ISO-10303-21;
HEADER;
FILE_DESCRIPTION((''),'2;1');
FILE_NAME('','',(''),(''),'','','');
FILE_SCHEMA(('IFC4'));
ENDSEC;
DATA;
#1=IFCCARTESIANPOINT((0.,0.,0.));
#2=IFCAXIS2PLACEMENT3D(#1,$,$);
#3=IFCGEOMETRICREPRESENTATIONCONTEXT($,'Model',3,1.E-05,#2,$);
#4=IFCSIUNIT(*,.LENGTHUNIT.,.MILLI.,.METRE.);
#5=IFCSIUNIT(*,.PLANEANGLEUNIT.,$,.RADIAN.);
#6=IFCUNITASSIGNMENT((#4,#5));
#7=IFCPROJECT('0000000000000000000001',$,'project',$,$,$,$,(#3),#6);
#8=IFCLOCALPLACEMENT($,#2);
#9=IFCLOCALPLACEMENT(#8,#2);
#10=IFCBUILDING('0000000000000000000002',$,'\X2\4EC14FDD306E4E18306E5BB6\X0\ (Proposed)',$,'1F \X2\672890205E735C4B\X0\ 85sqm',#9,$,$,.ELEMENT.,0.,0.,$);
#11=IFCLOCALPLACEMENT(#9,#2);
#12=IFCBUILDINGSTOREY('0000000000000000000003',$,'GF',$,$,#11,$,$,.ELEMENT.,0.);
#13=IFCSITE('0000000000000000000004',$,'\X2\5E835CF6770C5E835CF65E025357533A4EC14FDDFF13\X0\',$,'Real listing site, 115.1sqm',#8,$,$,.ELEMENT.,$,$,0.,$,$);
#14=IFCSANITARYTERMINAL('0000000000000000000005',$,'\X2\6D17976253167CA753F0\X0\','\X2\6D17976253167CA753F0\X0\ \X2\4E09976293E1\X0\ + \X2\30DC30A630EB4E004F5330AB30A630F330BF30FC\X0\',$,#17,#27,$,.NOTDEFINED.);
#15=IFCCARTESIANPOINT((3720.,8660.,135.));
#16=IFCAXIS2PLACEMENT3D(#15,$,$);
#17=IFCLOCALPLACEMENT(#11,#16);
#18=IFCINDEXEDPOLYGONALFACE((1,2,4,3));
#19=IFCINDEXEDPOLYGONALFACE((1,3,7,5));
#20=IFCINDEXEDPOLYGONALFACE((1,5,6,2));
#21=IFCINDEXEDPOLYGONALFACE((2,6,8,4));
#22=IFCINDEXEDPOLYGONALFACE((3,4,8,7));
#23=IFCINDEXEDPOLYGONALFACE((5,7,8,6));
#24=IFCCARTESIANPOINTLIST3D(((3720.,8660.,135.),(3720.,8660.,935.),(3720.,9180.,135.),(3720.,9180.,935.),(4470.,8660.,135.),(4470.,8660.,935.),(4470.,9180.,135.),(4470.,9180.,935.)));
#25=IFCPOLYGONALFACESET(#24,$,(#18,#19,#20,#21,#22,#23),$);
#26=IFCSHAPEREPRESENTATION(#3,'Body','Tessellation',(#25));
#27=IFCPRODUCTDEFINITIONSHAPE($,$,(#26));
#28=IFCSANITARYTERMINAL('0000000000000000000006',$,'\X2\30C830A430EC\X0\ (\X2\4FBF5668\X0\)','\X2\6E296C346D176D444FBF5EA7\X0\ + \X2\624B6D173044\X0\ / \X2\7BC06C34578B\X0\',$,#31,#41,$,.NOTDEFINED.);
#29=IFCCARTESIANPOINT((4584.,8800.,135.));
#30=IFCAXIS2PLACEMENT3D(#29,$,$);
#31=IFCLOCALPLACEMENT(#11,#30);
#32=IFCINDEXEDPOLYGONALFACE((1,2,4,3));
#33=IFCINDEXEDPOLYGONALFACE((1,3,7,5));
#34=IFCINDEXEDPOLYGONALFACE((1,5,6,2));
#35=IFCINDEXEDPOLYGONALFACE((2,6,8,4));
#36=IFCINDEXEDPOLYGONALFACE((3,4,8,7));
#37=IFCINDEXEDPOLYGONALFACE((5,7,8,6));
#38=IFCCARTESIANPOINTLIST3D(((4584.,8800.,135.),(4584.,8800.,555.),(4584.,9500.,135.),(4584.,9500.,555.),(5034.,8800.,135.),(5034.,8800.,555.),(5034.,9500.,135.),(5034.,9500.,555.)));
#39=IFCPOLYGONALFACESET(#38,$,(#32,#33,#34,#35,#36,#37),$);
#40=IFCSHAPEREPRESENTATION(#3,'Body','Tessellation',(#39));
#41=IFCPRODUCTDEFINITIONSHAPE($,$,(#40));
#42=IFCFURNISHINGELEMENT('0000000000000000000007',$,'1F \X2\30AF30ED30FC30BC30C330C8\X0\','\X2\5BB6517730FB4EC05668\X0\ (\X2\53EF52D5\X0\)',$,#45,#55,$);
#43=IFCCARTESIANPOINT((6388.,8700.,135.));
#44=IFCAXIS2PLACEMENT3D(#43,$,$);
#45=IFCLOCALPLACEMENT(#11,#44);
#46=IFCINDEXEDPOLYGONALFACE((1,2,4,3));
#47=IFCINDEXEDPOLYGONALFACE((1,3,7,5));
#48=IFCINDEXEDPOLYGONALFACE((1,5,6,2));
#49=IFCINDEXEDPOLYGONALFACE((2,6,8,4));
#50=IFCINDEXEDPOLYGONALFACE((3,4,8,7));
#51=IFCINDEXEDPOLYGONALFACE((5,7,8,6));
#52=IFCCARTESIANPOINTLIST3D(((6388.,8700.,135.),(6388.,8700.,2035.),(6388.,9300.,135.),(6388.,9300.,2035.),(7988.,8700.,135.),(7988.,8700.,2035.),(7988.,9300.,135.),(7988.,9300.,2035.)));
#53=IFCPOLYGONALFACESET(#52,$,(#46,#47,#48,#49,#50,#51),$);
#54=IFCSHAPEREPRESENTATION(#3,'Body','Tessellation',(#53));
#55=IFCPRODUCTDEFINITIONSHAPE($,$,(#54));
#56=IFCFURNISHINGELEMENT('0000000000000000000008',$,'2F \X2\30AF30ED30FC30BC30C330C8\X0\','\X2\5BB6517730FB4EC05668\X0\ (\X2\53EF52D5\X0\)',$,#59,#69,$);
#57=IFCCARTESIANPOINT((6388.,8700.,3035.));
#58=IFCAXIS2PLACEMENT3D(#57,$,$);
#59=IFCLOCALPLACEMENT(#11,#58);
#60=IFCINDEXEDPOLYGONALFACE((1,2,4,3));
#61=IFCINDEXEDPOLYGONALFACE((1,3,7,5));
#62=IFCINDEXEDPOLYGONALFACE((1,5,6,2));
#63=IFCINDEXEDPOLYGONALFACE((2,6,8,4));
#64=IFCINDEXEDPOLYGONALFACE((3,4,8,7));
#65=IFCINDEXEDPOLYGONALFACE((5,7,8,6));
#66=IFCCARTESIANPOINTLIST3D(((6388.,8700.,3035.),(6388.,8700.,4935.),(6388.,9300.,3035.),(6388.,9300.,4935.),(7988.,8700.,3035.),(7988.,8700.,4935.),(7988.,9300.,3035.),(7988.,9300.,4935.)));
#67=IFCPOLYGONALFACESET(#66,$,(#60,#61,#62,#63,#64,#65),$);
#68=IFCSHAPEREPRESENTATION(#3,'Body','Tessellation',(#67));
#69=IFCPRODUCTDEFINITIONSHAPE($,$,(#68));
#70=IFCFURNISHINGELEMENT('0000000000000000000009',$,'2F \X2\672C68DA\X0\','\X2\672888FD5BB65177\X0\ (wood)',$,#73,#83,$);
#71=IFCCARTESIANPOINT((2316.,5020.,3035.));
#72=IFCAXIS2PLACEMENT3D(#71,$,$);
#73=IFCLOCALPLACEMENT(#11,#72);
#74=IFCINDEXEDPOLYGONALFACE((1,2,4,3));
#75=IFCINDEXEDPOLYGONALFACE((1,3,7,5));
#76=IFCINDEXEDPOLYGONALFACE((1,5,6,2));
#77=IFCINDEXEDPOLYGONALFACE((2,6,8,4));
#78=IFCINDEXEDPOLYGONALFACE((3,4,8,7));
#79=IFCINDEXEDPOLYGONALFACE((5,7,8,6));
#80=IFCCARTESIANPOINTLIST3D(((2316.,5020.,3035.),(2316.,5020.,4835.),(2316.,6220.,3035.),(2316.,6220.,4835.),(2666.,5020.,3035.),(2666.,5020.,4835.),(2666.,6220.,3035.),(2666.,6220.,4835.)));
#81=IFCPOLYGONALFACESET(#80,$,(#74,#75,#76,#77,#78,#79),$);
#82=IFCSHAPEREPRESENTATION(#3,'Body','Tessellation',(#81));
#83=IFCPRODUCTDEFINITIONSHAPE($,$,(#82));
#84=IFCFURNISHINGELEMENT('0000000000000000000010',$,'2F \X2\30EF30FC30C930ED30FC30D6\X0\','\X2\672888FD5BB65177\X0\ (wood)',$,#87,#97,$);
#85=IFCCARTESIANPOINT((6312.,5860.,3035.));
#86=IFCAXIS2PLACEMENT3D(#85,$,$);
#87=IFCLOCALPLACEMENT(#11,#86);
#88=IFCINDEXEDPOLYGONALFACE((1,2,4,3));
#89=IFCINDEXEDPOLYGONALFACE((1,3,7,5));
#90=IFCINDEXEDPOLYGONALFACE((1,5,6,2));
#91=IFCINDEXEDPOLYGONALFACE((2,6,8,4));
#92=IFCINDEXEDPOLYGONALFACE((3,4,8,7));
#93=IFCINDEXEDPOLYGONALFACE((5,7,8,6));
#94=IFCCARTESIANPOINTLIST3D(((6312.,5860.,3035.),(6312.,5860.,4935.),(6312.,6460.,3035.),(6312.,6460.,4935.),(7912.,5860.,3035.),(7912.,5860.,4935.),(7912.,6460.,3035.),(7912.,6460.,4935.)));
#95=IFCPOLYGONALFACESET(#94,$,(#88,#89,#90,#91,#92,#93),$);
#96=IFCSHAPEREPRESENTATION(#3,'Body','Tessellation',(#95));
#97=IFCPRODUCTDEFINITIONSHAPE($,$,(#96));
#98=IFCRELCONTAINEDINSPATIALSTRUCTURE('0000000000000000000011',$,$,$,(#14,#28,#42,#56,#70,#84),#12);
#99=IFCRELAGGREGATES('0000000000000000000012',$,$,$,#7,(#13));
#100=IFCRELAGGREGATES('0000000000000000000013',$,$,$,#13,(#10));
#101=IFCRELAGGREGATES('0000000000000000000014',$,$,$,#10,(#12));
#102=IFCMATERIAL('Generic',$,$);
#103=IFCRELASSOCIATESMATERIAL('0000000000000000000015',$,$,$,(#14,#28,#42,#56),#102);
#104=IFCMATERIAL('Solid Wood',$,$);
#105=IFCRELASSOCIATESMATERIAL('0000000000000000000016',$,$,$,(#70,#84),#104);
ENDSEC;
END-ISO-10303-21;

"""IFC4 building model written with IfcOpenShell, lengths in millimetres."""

from ifc_helpers import new_model, si_unit, frame, frame_2d, origin, place, context, project, spatial, rectangle, extrude, material, element, save


model = new_model("IFC4")

# Units and contexts
model_context = context("Model", 3, precision=1e-05, world=origin())
ifc_project = project(units=[si_unit("LENGTHUNIT", "METRE", prefix="MILLI"), si_unit("PLANEANGLEUNIT", "RADIAN")], contexts=[model_context])

# Site, building, storey
site_placement = place(None, origin())
site = spatial("IfcSite", under=ifc_project, at=site_placement, Name="広島県広島市南区仁保３", ObjectType="Real listing site, 115.1sqm", CompositionType="ELEMENT", RefElevation=0.0)
building_placement = place(site_placement, origin())
building = spatial("IfcBuilding", under=site, at=building_placement, Name="仁保の丘の家 (Proposed)", ObjectType="1F 木造平屋 85sqm", CompositionType="ELEMENT", ElevationOfRefHeight=0.0, ElevationOfTerrain=0.0)
storey_placement = place(building_placement, origin())
storey = spatial("IfcBuildingStorey", under=building, at=storey_placement, Name="GF", CompositionType="ELEMENT", Elevation=0.0)

# Shared definitions
ifc_material_1 = material(Name="Solid Wood")

# Shared definitions
ifc_material_2 = material(Name="Generic")

# Sanitary terminals
sanitary_terminal_1_placement = place(storey_placement, frame((3720.0, 8660.0, 135.0)))
element("IfcSanitaryTerminal", 1, at=sanitary_terminal_1_placement, inside=storey, material=ifc_material_2, Name="洗面化粧台", Description="洗面化粧台 三面鏡 + ボウル一体カウンター", PredefinedType="NOTDEFINED", context=model_context, shape_type="SweptSolid", body=[
    extrude(rectangle(XDim=750.0, YDim=520.0, at=frame_2d((375.0, 260.0))), frame((3720.0, 8660.0, 135.0)), (0.0, 0.0, 1.0), 800.0),
])
sanitary_terminal_2_placement = place(storey_placement, frame((4584.0, 8800.0, 135.0)))
element("IfcSanitaryTerminal", 2, at=sanitary_terminal_2_placement, inside=storey, material=ifc_material_2, Name="トイレ (便器)", Description="温水洗浄便座 + 手洗い / 節水型", PredefinedType="NOTDEFINED", context=model_context, shape_type="SweptSolid", body=[
    extrude(rectangle(XDim=450.0, YDim=700.0, at=frame_2d((225.0, 350.0))), frame((4584.0, 8800.0, 135.0)), (0.0, 0.0, 1.0), 420.0),
])

# Furnishing elements
furnishing_1_placement = place(storey_placement, frame((6388.0, 8700.0, 135.0)))
element("IfcFurnishingElement", 3, at=furnishing_1_placement, inside=storey, material=ifc_material_2, Name="1F クローゼット", Description="家具・什器 (可動)", context=model_context, shape_type="SweptSolid", body=[
    extrude(rectangle(XDim=1600.0, YDim=600.0, at=frame_2d((800.0, 300.0))), frame((6388.0, 8700.0, 135.0)), (0.0, 0.0, 1.0), 1900.0),
])
furnishing_2_placement = place(storey_placement, frame((6388.0, 8700.0, 3035.0)))
element("IfcFurnishingElement", 4, at=furnishing_2_placement, inside=storey, material=ifc_material_2, Name="2F クローゼット", Description="家具・什器 (可動)", context=model_context, shape_type="SweptSolid", body=[
    extrude(rectangle(XDim=1600.0, YDim=600.0, at=frame_2d((800.0, 300.0))), frame((6388.0, 8700.0, 3035.0)), (0.0, 0.0, 1.0), 1900.0),
])
furnishing_3_placement = place(storey_placement, frame((2316.0, 5020.0, 3035.0)))
element("IfcFurnishingElement", 5, at=furnishing_3_placement, inside=storey, material=ifc_material_1, Name="2F 本棚", Description="木製家具 (wood)", context=model_context, shape_type="SweptSolid", body=[
    extrude(rectangle(XDim=350.0, YDim=1200.0, at=frame_2d((175.0, 600.0))), frame((2316.0, 5020.0, 3035.0)), (0.0, 0.0, 1.0), 1800.0),
])
furnishing_4_placement = place(storey_placement, frame((6312.0, 5860.0, 3035.0)))
element("IfcFurnishingElement", 6, at=furnishing_4_placement, inside=storey, material=ifc_material_1, Name="2F ワードローブ", Description="木製家具 (wood)", context=model_context, shape_type="SweptSolid", body=[
    extrude(rectangle(XDim=1600.0, YDim=600.0, at=frame_2d((800.0, 300.0))), frame((6312.0, 5860.0, 3035.0)), (0.0, 0.0, 1.0), 1900.0),
])

save(model, "model.ifc")
